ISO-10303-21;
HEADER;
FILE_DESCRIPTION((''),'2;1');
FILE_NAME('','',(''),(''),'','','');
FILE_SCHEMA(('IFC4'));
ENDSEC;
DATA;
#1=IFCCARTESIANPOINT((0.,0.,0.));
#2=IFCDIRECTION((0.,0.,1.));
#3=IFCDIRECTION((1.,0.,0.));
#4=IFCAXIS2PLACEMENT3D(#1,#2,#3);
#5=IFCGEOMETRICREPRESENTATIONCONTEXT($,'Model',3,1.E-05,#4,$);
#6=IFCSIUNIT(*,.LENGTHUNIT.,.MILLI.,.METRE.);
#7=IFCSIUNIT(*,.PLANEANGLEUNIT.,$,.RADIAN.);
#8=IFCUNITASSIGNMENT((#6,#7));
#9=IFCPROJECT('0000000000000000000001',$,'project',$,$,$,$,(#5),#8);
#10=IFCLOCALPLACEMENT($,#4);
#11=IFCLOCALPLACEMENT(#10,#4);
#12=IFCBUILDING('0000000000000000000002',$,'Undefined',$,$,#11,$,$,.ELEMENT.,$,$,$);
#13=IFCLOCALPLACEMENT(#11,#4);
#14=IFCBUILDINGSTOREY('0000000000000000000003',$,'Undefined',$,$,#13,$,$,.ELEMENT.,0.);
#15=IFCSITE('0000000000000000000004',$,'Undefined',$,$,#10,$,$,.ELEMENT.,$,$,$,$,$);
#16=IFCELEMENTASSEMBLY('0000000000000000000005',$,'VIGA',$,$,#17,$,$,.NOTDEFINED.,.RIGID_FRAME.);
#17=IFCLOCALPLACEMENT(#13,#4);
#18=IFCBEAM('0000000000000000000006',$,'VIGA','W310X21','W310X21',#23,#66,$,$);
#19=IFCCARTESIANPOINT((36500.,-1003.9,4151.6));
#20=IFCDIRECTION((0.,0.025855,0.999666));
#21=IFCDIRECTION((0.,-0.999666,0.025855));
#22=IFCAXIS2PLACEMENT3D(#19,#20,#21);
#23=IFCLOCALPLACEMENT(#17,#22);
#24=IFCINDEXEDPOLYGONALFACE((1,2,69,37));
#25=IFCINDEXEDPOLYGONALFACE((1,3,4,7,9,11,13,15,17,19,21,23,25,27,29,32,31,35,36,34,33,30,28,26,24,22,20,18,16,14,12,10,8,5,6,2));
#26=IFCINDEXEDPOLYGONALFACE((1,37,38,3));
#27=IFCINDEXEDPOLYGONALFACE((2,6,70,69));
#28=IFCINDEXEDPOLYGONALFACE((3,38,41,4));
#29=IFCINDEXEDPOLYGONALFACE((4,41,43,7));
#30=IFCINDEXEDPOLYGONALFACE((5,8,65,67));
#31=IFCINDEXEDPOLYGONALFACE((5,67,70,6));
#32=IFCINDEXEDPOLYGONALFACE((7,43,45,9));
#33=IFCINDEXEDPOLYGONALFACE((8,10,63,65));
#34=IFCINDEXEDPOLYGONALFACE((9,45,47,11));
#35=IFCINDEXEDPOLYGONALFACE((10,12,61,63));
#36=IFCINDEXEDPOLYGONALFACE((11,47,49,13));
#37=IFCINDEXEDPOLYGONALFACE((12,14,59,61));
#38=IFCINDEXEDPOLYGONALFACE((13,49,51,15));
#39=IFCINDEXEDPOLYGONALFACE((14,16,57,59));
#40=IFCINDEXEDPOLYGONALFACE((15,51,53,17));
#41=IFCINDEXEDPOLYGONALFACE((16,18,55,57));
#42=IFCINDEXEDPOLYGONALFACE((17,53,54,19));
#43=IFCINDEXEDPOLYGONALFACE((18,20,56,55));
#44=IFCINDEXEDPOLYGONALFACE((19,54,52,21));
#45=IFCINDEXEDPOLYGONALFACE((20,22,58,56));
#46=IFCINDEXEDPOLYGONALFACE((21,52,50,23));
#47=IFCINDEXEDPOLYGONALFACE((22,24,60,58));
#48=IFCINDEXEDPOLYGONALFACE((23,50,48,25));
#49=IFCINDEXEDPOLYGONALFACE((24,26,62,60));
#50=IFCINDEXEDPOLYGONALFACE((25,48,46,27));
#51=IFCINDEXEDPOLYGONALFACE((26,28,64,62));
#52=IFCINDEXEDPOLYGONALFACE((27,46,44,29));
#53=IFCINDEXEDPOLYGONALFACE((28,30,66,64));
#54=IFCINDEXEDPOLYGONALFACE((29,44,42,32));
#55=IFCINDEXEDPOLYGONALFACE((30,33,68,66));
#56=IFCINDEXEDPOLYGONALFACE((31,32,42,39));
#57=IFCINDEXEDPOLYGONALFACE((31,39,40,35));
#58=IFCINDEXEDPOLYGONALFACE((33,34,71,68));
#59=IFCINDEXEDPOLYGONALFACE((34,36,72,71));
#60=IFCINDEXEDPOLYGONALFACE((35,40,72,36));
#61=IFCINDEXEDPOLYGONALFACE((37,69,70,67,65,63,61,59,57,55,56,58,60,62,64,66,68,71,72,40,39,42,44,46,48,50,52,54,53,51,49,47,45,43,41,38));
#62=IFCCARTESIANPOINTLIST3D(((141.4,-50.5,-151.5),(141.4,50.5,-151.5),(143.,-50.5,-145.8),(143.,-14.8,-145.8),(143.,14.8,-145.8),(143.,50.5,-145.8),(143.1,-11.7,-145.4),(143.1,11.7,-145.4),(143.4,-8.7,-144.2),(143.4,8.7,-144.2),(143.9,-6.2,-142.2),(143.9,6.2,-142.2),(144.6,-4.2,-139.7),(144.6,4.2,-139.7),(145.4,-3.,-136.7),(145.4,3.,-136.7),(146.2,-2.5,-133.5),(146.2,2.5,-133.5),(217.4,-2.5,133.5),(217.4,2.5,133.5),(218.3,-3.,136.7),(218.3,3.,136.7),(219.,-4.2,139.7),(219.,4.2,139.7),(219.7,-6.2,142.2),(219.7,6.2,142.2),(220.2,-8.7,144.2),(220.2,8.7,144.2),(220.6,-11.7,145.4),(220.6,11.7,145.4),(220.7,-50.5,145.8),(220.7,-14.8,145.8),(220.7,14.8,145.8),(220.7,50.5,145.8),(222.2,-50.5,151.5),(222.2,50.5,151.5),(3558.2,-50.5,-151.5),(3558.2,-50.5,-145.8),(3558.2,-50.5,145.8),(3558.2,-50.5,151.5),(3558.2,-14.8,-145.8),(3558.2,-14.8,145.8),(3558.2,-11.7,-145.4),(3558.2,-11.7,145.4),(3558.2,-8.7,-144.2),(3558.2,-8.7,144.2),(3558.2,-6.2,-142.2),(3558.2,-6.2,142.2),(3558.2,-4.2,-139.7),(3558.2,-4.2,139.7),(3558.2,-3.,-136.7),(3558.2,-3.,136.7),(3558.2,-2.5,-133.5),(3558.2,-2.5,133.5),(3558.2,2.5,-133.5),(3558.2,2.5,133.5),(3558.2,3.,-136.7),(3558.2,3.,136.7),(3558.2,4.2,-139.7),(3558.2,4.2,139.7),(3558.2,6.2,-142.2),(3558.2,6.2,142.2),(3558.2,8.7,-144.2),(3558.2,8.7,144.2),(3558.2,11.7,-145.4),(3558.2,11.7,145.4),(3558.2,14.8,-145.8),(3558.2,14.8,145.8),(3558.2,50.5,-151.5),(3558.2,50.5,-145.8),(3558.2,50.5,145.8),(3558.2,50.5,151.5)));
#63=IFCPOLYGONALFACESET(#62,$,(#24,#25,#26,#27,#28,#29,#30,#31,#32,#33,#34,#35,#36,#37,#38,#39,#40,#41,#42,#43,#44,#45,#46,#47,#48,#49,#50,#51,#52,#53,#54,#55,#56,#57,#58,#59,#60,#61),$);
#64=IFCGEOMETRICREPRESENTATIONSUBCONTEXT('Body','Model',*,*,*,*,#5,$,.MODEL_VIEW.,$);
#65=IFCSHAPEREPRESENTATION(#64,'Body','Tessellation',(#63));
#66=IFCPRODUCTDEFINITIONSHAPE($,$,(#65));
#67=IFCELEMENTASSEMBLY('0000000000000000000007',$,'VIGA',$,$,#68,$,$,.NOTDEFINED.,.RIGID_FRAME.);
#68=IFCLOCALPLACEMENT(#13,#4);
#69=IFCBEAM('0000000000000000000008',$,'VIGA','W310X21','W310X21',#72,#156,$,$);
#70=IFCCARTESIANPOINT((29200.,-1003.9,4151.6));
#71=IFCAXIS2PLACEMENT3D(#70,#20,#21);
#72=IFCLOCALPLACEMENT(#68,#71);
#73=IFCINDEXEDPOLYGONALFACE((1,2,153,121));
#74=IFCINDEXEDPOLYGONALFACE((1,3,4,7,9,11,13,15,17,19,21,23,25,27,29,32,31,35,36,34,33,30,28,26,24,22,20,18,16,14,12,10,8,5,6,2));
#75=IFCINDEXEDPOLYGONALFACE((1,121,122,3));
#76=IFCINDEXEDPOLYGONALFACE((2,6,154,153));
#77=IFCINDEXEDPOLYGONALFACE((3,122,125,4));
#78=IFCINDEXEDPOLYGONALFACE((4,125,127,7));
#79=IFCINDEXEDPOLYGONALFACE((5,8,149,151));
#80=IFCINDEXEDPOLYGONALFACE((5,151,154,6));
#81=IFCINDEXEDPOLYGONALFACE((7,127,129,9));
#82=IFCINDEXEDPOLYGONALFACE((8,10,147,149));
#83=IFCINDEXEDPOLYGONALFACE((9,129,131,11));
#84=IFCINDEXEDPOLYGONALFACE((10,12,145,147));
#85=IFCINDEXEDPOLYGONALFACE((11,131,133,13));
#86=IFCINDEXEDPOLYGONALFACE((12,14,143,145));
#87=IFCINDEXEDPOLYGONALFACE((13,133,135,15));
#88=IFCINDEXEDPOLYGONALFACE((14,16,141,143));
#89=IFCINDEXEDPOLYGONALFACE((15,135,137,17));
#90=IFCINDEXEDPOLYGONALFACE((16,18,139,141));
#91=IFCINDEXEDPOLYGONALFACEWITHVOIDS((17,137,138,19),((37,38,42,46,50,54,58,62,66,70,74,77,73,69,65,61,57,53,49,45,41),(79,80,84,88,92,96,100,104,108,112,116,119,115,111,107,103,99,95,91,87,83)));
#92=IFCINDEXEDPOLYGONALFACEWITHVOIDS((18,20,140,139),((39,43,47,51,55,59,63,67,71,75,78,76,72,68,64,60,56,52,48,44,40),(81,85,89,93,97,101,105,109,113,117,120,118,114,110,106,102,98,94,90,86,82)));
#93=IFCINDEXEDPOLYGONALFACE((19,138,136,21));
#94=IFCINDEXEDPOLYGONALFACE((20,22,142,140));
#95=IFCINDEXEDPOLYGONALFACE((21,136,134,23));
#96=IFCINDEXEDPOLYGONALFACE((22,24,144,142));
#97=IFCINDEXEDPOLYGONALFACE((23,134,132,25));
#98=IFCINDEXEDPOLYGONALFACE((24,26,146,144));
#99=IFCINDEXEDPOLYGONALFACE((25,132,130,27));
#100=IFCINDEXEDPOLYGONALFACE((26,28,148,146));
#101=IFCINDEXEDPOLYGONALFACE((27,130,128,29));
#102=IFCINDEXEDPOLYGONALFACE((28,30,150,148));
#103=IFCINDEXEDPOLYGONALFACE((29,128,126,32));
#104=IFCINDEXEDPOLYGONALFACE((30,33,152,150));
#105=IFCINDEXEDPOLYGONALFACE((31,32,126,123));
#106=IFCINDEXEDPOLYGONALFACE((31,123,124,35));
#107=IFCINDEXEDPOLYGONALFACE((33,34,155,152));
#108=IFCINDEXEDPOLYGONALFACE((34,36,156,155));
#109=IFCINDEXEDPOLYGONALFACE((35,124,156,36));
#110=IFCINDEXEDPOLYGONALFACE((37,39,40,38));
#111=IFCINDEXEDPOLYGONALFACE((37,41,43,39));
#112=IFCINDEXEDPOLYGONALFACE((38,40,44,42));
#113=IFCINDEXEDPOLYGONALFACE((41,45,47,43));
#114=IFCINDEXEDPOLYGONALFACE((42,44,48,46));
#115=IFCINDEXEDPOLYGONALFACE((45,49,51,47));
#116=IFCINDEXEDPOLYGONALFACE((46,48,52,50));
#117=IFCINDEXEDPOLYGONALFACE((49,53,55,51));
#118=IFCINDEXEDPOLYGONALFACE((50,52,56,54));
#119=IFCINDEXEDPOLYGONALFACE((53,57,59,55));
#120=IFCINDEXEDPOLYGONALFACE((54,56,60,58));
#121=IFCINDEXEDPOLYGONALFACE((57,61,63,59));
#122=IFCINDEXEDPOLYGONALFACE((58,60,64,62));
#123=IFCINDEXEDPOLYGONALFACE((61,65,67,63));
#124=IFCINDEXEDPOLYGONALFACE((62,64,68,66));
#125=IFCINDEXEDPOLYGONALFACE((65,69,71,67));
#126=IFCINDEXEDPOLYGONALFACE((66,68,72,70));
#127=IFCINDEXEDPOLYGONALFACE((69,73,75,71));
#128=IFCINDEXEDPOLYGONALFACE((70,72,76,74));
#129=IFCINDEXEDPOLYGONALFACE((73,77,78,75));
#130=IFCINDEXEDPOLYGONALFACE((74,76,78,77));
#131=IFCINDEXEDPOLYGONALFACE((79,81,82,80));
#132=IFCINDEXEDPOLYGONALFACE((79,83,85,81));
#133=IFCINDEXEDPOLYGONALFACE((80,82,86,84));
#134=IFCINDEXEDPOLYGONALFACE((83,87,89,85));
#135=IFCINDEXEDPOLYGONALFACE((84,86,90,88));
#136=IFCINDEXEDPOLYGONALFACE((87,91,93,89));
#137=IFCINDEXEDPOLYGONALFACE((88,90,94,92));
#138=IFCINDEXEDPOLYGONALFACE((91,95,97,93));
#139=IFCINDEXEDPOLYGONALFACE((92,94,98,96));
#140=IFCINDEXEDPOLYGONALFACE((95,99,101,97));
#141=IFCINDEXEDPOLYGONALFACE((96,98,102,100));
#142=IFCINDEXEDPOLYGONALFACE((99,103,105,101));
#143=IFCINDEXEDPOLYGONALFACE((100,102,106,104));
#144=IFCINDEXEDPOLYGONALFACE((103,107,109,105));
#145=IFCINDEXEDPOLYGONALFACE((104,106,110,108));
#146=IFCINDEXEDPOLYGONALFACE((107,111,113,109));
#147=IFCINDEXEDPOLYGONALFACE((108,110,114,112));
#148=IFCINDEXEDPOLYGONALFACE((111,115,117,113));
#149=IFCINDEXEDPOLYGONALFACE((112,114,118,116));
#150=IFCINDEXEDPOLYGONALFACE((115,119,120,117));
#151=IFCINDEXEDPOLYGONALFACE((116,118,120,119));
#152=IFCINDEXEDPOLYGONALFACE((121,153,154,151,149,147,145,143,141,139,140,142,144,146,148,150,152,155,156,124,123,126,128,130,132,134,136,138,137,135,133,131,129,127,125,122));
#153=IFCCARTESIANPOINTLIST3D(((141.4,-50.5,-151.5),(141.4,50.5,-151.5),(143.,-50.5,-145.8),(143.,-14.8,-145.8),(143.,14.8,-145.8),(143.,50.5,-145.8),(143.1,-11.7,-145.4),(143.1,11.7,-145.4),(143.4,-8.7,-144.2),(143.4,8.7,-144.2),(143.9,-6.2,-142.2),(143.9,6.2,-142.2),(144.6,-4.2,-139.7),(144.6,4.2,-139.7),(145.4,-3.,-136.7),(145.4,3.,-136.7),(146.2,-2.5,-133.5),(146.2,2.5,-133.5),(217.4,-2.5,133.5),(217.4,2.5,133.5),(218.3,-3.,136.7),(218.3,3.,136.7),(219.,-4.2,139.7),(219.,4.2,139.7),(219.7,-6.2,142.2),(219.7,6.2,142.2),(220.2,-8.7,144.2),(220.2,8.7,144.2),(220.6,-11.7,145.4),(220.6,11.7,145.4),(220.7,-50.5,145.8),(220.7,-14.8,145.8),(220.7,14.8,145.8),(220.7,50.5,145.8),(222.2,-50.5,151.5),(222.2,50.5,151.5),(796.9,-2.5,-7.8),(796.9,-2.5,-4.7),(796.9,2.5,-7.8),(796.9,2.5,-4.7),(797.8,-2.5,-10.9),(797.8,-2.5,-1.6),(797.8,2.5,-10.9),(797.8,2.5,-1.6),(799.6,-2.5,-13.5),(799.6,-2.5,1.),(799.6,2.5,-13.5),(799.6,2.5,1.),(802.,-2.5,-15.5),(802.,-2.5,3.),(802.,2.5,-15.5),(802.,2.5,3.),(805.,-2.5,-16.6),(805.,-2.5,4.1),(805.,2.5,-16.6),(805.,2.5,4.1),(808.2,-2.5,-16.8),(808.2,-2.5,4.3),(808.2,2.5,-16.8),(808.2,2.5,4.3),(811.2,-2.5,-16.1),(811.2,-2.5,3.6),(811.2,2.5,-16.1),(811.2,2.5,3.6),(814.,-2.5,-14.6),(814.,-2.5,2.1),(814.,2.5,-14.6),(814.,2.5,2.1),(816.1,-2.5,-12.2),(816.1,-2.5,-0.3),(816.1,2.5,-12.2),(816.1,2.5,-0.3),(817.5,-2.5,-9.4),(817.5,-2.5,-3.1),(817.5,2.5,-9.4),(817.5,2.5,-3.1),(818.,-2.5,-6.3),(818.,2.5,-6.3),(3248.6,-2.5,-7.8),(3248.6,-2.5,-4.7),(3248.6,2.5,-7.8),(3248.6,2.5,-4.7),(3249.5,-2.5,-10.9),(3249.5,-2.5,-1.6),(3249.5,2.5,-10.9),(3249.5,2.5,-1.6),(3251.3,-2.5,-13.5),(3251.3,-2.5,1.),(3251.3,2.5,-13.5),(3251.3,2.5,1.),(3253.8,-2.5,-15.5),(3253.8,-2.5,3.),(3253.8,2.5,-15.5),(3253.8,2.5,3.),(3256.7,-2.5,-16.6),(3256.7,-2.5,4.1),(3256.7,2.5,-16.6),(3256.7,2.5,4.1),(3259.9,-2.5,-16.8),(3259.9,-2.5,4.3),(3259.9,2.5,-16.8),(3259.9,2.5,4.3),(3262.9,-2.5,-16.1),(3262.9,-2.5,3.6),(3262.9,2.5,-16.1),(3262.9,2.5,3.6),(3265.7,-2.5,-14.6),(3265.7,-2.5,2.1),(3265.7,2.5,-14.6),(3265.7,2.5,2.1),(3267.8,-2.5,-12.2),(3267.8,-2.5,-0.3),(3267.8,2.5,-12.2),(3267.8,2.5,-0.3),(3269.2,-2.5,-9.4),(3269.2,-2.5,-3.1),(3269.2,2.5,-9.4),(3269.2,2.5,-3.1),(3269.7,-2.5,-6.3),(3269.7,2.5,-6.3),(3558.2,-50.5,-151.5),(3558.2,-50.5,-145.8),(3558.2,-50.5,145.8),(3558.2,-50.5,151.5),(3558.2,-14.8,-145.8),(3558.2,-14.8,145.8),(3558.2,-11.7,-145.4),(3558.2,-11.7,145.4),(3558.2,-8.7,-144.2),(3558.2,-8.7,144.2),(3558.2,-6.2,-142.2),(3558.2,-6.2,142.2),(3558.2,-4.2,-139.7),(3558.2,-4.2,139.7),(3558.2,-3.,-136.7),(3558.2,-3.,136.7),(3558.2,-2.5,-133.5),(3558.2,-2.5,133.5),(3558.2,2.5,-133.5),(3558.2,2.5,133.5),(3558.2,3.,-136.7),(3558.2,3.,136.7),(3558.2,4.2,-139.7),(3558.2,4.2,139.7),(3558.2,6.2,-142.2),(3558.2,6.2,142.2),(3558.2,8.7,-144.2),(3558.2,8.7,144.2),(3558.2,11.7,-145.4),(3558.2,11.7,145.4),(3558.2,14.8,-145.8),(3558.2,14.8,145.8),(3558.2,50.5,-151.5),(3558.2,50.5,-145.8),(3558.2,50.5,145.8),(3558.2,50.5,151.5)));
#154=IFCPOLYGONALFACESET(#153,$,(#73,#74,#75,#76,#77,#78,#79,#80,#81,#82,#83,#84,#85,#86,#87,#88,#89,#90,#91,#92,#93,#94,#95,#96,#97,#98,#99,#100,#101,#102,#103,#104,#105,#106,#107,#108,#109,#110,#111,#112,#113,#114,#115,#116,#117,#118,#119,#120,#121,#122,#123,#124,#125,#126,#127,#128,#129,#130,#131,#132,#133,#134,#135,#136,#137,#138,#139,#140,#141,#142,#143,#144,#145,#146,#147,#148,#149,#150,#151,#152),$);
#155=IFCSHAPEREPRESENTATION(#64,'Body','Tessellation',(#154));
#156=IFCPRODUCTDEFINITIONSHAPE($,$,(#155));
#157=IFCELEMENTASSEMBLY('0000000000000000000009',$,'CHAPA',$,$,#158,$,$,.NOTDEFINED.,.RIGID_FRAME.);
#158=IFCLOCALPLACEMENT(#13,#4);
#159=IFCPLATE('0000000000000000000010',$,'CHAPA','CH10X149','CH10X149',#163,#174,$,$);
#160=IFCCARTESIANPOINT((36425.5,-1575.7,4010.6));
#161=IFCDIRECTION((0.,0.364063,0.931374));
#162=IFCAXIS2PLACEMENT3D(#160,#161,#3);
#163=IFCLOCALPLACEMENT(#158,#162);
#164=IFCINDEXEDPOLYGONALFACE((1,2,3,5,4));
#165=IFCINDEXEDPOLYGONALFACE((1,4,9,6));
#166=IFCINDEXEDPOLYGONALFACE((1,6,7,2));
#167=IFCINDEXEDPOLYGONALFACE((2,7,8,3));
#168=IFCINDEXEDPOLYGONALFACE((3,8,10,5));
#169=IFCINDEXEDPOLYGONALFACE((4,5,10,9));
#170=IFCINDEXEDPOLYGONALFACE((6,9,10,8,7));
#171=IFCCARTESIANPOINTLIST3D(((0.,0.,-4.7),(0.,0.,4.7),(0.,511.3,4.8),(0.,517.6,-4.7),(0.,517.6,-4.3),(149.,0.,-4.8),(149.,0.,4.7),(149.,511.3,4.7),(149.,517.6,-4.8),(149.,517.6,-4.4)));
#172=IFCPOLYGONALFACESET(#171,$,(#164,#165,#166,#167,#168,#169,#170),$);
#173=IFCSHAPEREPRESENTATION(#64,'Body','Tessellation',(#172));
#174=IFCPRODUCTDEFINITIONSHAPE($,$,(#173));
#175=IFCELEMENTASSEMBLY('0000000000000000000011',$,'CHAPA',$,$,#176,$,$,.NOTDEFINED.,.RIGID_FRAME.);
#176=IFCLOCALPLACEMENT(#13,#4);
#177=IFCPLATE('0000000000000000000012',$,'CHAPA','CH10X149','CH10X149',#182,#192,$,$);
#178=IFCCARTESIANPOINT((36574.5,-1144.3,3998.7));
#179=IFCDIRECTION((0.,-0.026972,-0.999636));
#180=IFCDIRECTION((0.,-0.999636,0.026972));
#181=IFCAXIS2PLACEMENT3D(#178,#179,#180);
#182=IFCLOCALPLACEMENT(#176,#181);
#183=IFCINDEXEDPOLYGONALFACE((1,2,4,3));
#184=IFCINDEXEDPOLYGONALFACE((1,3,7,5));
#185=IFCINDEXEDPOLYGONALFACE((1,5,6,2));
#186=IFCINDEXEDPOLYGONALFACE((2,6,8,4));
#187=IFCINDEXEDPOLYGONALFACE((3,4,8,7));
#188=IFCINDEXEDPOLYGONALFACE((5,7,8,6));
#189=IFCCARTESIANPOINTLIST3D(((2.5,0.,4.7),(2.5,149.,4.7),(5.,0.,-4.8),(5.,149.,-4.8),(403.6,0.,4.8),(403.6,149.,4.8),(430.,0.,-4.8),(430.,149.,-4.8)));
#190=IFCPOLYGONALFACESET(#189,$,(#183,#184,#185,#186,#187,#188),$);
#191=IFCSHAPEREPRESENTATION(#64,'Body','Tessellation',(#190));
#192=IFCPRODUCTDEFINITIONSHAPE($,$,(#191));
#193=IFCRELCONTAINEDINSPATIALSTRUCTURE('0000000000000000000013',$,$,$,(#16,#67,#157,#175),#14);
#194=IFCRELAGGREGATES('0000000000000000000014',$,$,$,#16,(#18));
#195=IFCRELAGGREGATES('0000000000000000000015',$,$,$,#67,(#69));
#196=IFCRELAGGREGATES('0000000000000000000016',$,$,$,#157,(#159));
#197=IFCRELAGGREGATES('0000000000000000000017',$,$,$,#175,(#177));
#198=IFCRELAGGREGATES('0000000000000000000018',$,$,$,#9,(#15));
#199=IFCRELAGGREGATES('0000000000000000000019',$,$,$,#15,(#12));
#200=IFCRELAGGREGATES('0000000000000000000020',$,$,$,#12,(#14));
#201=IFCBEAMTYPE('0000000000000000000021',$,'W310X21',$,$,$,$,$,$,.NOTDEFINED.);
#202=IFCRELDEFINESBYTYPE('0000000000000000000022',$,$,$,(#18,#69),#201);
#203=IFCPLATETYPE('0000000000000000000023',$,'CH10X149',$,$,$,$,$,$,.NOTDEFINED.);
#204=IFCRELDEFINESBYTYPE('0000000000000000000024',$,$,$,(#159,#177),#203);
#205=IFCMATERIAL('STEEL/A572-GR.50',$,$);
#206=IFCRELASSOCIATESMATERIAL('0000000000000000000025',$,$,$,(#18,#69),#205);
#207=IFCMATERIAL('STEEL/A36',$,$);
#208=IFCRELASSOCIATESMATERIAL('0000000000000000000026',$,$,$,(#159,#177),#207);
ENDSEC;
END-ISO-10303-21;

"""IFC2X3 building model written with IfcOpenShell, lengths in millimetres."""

from ifc_helpers import new_model, si_unit, frame, origin_with_axes, origin_2d_with_axis, place, context, subcontext, project, spatial, polyline, circle, i_section, outline, extrude, boolean, clip, halfspace, material, type_object, element, aggregate, save


model = new_model("IFC2X3")

# Units and contexts
model_context = context("Model", 3, precision=1e-05, world=origin_with_axes())
body_context = subcontext(model_context, "Body", "Model", "MODEL_VIEW")
ifc_project = project(units=[si_unit("LENGTHUNIT", "METRE", prefix="MILLI"), si_unit("PLANEANGLEUNIT", "RADIAN")], contexts=[model_context])

# Site, building, storey
site_placement = place(None, origin_with_axes())
site = spatial("IfcSite", under=ifc_project, at=site_placement, Name="Undefined", CompositionType="ELEMENT")
building_placement = place(site_placement, origin_with_axes())
building = spatial("IfcBuilding", under=site, at=building_placement, Name="Undefined", CompositionType="ELEMENT")
storey_placement = place(building_placement, origin_with_axes())
storey = spatial("IfcBuildingStorey", under=building, at=storey_placement, Name="Undefined", CompositionType="ELEMENT", Elevation=0.0)

# Element assemblies, beams
ifc_material_1 = material(Name="STEEL/A572-GR.50")
assembly_1_placement = place(storey_placement, origin_with_axes())
assembly_1 = element("IfcElementAssembly", 1, at=assembly_1_placement, inside=storey, Name="VIGA", AssemblyPlace="NOTDEFINED", PredefinedType="RIGID_FRAME")
beam_type_1 = type_object("IfcBeamType", Name="W310X21", PredefinedType="NOTDEFINED")
beam_1_placement = place(assembly_1_placement, frame((36500.0, -1003.9, 4151.6), z_axis=(0.0, 0.025855, 0.999666), x_axis=(0.0, -0.999666, 0.025855)))
beam_1 = element("IfcBeam", 2, at=beam_1_placement, type_object=beam_type_1, material=ifc_material_1, Name="VIGA", Description="W310X21", ObjectType="W310X21", context=body_context, shape_type="Clipping", body=[
    clip(extrude(i_section(OverallWidth=101.0, OverallDepth=303.0, WebThickness=5.1, FlangeThickness=5.7, FilletRadius=12.3, at=origin_2d_with_axis()), frame((3558.2, 0.0, 0.0), z_axis=(-1.0, 0.0, 0.0), x_axis=(0.0, -1.0, 0.0)), (0.0, 0.0, 1.0), 3558.2), halfspace(frame((141.4, 50.5, -151.7), z_axis=(-0.966259, 0.0, 0.257573), x_axis=(0.257573, 0.0, 0.966259)), False)),
])
aggregate(assembly_1, [beam_1])
assembly_2_placement = place(storey_placement, origin_with_axes())
assembly_2 = element("IfcElementAssembly", 3, at=assembly_2_placement, inside=storey, Name="VIGA", AssemblyPlace="NOTDEFINED", PredefinedType="RIGID_FRAME")
beam_2_placement = place(assembly_2_placement, frame((29200.0, -1003.9, 4151.6), z_axis=(0.0, 0.025855, 0.999666), x_axis=(0.0, -0.999666, 0.025855)))
beam_2 = element("IfcBeam", 4, at=beam_2_placement, type_object=beam_type_1, material=ifc_material_1, Name="VIGA", Description="W310X21", ObjectType="W310X21", context=body_context, shape_type="CSG", body=[
    boolean("DIFFERENCE", boolean("DIFFERENCE", boolean("DIFFERENCE", extrude(i_section(OverallWidth=101.0, OverallDepth=303.0, WebThickness=5.1, FlangeThickness=5.7, FilletRadius=12.3, at=origin_2d_with_axis()), frame((3558.2, 0.0, 0.0), z_axis=(-1.0, 0.0, 0.0), x_axis=(0.0, -1.0, 0.0)), (0.0, 0.0, 1.0), 3558.2), extrude(circle(Radius=10.6, at=origin_2d_with_axis()), frame((3259.1, 100.0, -6.3), z_axis=(0.0, -1.0, 0.0), x_axis=(1.0, 0.0, 0.0)), (0.0, 0.0, 1.0), 200.0)), extrude(circle(Radius=10.6, at=origin_2d_with_axis()), frame((807.4, 100.0, -6.3), z_axis=(0.0, -1.0, 0.0), x_axis=(1.0, 0.0, 0.0)), (0.0, 0.0, 1.0), 200.0)), halfspace(frame((141.4, 50.5, -151.7), z_axis=(-0.966259, 0.0, 0.257573), x_axis=(0.257573, 0.0, 0.966259)), False)),
])
aggregate(assembly_2, [beam_2])

# Shared definitions
ifc_material_2 = material(Name="STEEL/A36")

# Element assemblies, plates
assembly_3_placement = place(storey_placement, origin_with_axes())
assembly_3 = element("IfcElementAssembly", 5, at=assembly_3_placement, inside=storey, Name="CHAPA", AssemblyPlace="NOTDEFINED", PredefinedType="RIGID_FRAME")
plate_type_1 = type_object("IfcPlateType", Name="CH10X149", PredefinedType="NOTDEFINED")
plate_1_placement = place(assembly_3_placement, frame((36425.5, -1575.7, 4010.6), z_axis=(0.0, 0.364063, 0.931374), x_axis=(1.0, 0.0, 0.0)))
plate_1 = element("IfcPlate", 6, at=plate_1_placement, type_object=plate_type_1, material=ifc_material_2, Name="CHAPA", Description="CH10X149", ObjectType="CH10X149", context=body_context, shape_type="Clipping", body=[
    clip(extrude(outline(polyline([(0.0, 0.0), (149.0, 0.0), (149.0, 517.6), (0.0, 517.6), (0.0, 0.0)])), frame((0.0, 0.0, -4.8), z_axis=(0.0, 0.0, 1.0), x_axis=(1.0, 0.0, 0.0)), (0.0, 0.0, 1.0), 9.5), halfspace(frame((149.0, 517.9, -4.7), z_axis=(0.0, 0.821204, 0.570634), x_axis=(0.0, -0.570634, 0.821204)), False)),
])
aggregate(assembly_3, [plate_1])
assembly_4_placement = place(storey_placement, origin_with_axes())
assembly_4 = element("IfcElementAssembly", 7, at=assembly_4_placement, inside=storey, Name="CHAPA", AssemblyPlace="NOTDEFINED", PredefinedType="RIGID_FRAME")
plate_2_placement = place(assembly_4_placement, frame((36574.5, -1144.3, 3998.7), z_axis=(0.0, -0.026972, -0.999636), x_axis=(0.0, -0.999636, 0.026972)))
plate_2 = element("IfcPlate", 8, at=plate_2_placement, type_object=plate_type_1, material=ifc_material_2, Name="CHAPA", Description="CH10X149", ObjectType="CH10X149", context=body_context, shape_type="Clipping", body=[
    clip(clip(extrude(outline(polyline([(0.0, 0.0), (430.0, 0.0), (430.0, 149.0), (0.0, 149.0), (0.0, 0.0)])), frame((0.0, 0.0, -4.8), z_axis=(0.0, 0.0, 1.0), x_axis=(1.0, 0.0, 0.0)), (0.0, 0.0, 1.0), 9.5), halfspace(frame((403.6, -500.0, 4.7), z_axis=(0.33881, 0.0, 0.940855), x_axis=(0.0, 1.0, 0.0)), False)), halfspace(frame((5.0, -500.0, -4.8), z_axis=(-0.965989, 0.0, -0.258583), x_axis=(0.0, 1.0, 0.0)), False)),
])
aggregate(assembly_4, [plate_2])

save(model, "model.ifc")
